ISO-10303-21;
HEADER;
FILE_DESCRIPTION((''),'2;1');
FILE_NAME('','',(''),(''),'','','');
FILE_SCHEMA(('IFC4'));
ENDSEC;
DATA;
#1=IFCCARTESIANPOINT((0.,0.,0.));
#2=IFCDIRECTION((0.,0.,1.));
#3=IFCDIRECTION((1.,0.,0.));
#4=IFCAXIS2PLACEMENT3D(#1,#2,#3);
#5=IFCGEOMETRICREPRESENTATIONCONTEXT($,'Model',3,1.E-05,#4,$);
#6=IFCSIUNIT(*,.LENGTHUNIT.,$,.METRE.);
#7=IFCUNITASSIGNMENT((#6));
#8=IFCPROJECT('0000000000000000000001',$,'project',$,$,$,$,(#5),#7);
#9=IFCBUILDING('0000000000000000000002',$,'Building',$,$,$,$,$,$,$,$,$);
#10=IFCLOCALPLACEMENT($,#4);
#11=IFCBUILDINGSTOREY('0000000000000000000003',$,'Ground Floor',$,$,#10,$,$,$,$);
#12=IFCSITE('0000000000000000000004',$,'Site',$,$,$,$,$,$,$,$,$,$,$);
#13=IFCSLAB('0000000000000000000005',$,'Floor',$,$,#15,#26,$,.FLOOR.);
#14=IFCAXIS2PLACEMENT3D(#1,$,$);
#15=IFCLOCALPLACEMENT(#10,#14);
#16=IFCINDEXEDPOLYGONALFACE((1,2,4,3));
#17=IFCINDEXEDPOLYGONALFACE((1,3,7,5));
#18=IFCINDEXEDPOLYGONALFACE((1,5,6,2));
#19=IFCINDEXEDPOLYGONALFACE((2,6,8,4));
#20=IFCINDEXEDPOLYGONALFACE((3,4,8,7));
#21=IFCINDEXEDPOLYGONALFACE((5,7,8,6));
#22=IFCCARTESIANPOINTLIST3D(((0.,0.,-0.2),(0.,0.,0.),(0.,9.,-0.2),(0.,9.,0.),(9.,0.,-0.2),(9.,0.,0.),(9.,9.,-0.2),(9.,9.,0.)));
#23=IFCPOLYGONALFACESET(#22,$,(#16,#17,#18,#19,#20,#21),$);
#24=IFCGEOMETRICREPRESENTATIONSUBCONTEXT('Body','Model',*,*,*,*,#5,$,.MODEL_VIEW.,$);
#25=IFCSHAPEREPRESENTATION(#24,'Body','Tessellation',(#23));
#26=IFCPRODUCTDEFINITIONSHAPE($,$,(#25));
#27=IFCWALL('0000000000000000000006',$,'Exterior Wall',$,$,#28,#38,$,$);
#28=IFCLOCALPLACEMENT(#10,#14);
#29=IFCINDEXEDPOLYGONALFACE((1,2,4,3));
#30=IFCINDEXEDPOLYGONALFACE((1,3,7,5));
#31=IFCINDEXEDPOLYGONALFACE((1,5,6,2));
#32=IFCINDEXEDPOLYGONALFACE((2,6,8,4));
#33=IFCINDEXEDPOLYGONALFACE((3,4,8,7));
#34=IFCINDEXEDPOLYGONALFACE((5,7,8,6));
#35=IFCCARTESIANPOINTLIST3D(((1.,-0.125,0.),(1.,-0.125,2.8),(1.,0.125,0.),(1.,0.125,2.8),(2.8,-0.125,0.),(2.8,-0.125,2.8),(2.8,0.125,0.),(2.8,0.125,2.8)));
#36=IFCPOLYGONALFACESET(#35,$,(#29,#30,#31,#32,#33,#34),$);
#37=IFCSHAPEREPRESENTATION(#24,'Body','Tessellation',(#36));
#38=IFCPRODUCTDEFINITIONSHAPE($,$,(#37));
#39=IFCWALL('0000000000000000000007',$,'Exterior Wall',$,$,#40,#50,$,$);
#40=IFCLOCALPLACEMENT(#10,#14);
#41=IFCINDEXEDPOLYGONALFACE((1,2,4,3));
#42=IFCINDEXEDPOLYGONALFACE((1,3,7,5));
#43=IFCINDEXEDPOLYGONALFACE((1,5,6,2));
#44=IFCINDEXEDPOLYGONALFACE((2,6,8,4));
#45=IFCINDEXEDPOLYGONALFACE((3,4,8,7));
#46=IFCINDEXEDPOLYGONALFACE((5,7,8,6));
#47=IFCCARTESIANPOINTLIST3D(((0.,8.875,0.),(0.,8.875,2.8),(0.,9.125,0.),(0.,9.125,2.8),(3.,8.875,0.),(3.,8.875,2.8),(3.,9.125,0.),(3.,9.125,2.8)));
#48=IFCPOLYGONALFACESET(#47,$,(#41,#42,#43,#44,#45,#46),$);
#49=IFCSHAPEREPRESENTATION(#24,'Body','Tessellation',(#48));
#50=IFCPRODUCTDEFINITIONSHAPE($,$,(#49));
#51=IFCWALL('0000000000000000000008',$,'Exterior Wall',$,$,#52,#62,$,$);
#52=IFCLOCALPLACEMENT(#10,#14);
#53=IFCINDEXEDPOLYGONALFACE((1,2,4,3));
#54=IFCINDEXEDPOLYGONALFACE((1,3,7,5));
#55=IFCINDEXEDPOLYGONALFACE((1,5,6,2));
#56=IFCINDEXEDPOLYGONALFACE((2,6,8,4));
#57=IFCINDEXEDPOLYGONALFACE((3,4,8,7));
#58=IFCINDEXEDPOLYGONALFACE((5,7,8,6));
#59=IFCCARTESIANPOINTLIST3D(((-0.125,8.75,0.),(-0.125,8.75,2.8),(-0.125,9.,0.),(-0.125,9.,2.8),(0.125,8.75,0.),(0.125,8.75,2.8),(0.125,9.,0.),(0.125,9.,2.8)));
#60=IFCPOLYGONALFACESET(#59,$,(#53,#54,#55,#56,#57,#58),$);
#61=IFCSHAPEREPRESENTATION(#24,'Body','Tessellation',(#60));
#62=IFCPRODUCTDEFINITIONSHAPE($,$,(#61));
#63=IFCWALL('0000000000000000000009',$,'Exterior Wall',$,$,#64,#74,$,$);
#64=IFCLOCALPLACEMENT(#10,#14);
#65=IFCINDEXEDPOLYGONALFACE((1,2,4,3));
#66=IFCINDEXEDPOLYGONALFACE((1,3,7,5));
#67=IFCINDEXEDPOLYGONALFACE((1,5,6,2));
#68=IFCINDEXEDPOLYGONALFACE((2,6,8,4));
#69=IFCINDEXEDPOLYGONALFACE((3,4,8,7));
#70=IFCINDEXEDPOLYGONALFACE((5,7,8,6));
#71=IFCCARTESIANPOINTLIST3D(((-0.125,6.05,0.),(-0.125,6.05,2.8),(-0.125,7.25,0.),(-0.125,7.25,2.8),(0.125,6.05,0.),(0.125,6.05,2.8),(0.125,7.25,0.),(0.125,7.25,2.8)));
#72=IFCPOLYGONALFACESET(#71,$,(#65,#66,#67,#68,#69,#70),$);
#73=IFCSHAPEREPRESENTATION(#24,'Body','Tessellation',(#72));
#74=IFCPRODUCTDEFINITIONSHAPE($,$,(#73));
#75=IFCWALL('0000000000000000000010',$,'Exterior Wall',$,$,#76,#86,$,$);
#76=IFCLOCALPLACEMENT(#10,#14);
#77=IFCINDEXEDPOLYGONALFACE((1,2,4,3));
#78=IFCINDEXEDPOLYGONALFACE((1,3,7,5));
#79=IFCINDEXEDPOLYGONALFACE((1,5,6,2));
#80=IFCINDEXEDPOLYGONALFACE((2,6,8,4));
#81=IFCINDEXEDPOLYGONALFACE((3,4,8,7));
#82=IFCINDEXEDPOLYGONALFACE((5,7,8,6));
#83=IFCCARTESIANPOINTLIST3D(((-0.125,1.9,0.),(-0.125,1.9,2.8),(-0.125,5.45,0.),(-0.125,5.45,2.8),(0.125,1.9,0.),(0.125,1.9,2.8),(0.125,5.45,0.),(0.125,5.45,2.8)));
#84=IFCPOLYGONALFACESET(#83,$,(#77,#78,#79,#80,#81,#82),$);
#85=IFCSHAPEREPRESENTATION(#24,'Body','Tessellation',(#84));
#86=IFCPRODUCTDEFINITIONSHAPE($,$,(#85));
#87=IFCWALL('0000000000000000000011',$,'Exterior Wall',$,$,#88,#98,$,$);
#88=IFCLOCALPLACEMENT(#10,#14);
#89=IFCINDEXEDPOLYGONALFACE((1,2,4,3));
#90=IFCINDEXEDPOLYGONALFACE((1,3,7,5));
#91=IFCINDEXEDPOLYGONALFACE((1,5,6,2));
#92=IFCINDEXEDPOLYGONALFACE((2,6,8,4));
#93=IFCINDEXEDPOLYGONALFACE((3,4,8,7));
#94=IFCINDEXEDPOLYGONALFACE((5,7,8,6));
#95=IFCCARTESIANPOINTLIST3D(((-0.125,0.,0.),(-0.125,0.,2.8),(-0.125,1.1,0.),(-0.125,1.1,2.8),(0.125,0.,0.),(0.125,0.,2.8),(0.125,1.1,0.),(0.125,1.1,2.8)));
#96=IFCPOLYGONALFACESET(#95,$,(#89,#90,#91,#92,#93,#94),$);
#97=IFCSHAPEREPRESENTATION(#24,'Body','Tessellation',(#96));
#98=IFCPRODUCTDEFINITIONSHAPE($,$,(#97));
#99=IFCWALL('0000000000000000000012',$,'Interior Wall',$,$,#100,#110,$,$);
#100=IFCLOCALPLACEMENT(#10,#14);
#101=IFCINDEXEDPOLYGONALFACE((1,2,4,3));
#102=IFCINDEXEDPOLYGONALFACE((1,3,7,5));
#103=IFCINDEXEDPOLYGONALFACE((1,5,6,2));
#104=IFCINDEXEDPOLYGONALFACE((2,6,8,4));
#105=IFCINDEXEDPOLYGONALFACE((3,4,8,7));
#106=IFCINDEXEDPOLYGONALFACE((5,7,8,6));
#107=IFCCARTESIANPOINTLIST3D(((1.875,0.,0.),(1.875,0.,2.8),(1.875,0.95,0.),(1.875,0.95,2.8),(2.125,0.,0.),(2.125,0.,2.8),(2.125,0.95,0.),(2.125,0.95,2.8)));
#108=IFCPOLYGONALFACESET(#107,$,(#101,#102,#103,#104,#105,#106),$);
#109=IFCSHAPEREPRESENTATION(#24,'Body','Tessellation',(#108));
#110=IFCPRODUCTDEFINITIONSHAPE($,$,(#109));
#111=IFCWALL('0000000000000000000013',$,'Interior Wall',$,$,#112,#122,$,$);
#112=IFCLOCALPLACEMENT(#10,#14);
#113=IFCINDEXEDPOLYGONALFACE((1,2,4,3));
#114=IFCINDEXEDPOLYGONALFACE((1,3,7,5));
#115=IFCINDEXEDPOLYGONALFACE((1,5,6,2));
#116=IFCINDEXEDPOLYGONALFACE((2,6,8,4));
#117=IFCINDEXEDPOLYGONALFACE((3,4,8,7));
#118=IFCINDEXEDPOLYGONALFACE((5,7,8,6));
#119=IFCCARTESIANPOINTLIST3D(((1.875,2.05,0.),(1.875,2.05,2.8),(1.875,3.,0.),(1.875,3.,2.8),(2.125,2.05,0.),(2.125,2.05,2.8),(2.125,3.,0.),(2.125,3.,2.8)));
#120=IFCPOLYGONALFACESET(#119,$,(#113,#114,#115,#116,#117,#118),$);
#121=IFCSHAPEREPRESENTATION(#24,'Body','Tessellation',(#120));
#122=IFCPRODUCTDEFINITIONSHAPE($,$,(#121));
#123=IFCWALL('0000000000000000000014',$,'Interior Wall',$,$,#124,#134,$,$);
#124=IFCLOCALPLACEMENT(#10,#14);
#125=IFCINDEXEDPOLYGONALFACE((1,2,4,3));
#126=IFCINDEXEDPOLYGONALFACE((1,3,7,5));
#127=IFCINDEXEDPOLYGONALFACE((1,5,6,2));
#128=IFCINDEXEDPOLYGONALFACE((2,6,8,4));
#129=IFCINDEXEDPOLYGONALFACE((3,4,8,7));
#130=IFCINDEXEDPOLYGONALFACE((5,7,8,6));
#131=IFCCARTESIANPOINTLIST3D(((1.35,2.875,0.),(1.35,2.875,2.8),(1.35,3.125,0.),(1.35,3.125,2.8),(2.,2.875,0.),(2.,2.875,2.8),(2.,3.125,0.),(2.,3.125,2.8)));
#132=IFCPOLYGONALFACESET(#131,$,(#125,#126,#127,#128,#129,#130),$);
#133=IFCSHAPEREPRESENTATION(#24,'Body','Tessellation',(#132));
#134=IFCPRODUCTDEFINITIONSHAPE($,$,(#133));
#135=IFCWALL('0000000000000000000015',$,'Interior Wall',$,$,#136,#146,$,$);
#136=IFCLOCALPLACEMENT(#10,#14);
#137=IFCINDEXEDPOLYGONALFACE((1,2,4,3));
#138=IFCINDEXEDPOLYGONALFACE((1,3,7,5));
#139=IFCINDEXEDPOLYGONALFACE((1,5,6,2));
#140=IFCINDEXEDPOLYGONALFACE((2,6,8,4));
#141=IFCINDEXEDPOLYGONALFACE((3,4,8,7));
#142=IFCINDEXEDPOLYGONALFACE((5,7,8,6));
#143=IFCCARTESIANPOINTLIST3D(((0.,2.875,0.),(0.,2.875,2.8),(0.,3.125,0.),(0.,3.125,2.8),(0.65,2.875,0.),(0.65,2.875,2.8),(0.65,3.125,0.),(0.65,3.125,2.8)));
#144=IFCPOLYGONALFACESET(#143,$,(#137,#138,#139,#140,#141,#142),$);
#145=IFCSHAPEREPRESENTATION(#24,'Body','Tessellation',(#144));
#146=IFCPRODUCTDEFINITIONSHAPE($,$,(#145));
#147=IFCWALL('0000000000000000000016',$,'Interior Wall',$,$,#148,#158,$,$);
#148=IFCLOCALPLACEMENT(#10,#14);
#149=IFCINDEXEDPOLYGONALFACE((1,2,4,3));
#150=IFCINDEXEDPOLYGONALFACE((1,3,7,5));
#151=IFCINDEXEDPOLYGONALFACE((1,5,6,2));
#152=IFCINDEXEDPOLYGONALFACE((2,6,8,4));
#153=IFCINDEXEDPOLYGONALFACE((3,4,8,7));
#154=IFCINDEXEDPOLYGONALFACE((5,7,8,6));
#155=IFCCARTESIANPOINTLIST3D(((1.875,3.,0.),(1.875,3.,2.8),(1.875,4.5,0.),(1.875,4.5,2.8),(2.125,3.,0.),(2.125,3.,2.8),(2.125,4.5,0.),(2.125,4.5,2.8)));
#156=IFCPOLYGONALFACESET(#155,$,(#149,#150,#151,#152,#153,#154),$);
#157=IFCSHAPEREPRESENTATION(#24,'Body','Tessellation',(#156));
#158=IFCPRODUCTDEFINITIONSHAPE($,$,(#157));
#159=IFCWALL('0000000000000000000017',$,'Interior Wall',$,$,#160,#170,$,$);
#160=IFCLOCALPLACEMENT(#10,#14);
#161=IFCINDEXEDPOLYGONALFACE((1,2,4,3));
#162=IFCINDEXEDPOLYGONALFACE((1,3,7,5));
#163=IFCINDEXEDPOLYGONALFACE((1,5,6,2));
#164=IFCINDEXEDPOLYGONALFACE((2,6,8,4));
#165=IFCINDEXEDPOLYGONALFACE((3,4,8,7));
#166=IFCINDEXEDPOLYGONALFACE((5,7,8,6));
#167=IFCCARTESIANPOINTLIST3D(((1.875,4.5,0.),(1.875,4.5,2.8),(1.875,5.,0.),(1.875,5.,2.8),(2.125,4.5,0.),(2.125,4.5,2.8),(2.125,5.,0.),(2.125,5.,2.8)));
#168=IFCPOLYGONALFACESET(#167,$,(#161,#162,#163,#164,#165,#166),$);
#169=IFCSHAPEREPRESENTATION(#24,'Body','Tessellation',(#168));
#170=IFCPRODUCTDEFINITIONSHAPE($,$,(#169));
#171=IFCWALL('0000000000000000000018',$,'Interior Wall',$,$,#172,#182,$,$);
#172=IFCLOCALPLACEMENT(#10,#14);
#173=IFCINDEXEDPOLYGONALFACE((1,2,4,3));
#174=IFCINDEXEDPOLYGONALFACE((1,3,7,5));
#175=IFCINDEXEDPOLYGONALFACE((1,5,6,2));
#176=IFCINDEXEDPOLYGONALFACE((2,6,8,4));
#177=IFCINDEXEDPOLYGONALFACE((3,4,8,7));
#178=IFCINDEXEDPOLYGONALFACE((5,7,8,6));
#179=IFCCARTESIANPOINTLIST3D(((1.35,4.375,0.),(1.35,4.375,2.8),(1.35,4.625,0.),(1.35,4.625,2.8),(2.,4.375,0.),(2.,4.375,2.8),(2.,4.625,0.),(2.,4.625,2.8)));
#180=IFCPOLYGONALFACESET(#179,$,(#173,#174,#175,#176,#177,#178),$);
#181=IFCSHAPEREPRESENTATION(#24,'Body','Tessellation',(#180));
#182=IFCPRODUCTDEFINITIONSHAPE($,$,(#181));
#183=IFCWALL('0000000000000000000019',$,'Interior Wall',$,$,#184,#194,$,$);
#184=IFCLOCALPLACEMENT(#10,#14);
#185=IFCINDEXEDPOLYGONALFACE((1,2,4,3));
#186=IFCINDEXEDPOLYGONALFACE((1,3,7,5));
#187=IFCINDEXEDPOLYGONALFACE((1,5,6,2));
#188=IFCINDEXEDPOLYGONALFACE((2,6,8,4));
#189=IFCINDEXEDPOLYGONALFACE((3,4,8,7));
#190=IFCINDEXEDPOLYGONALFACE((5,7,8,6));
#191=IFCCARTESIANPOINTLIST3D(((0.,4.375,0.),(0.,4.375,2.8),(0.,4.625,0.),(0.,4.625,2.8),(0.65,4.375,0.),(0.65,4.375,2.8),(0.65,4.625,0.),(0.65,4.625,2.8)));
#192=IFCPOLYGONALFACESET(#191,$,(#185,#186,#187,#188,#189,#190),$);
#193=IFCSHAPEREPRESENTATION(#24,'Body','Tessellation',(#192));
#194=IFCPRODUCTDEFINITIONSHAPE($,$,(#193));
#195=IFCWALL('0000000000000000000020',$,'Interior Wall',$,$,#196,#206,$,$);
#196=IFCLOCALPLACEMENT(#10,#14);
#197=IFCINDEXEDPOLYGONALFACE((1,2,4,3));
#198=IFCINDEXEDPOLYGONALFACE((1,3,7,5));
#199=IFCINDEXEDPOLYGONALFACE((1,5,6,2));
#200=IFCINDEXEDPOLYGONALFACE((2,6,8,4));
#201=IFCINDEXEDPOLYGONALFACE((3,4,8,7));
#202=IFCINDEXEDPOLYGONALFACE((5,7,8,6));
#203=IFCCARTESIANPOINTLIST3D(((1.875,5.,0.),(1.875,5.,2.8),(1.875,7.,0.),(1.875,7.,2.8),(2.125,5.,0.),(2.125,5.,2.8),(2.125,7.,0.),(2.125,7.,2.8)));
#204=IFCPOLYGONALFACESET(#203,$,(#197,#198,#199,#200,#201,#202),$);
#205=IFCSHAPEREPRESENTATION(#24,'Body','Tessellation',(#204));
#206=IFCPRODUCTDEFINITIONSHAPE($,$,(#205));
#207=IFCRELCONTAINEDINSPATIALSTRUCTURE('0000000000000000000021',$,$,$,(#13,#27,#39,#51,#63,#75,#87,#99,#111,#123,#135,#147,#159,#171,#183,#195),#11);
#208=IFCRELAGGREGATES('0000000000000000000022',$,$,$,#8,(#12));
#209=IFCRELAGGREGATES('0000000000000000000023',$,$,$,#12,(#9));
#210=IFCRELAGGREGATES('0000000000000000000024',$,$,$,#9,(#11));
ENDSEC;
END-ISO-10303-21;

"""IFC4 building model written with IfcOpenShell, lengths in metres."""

from ifc_helpers import new_model, si_unit, frame, origin_with_axes, place, context, subcontext, project, spatial, indexed_curve, outline, extrude, element, save


model = new_model("IFC4")

# Units and contexts
model_context = context("Model", 3, precision=1e-05, world=origin_with_axes())
body_context = subcontext(model_context, "Body", "Model", "MODEL_VIEW")
ifc_project = project(units=[si_unit("LENGTHUNIT", "METRE")], contexts=[model_context])

# Site, building, storey
site = spatial("IfcSite", under=ifc_project, Name="Site")
building = spatial("IfcBuilding", under=site, Name="Building")
storey_placement = place(None, origin_with_axes())
storey = spatial("IfcBuildingStorey", under=building, at=storey_placement, Name="Ground Floor")

# Slab
slab_placement = place(storey_placement, frame((0.0, 0.0, -0.2), z_axis=(0.0, 0.0, 1.0), x_axis=(1.0, 0.0, 0.0)))
element("IfcSlab", 1, at=slab_placement, inside=storey, Name="Floor", PredefinedType="FLOOR", context=body_context, shape_type="SweptSolid", body=[
    extrude(outline(indexed_curve([(0.0, 0.0), (9.0, 0.0), (9.0, 9.0), (0.0, 9.0)])), None, (0.0, 0.0, 1.0), 0.2),
])

# Walls
wall_1_placement = place(storey_placement, frame((1.0, 0.0, 0.0), z_axis=(0.0, 0.0, 1.0), x_axis=(1.0, 0.0, 0.0)))
element("IfcWall", 2, at=wall_1_placement, inside=storey, Name="Exterior Wall", context=body_context, shape_type="SweptSolid", body=[
    extrude(outline(indexed_curve([(0.0, 0.0), (0.0, 0.25), (1.8, 0.25), (1.8, 0.0), (0.0, 0.0)], self_intersect=False)), frame((0.0, -0.125, 0.0), z_axis=(0.0, 0.0, 1.0), x_axis=(1.0, 0.0, 0.0)), (0.0, 0.0, 1.0), 2.8),
])
wall_2_placement = place(storey_placement, frame((3.0, 9.0, 0.0), z_axis=(0.0, 0.0, 1.0), x_axis=(-1.0, 0.0, 0.0)))
element("IfcWall", 3, at=wall_2_placement, inside=storey, Name="Exterior Wall", context=body_context, shape_type="SweptSolid", body=[
    extrude(outline(indexed_curve([(0.0, 0.0), (0.0, 0.25), (3.0, 0.25), (3.0, 0.0), (0.0, 0.0)], self_intersect=False)), frame((0.0, -0.125, 0.0), z_axis=(0.0, 0.0, 1.0), x_axis=(1.0, 0.0, 0.0)), (0.0, 0.0, 1.0), 2.8),
])
wall_3_placement = place(storey_placement, frame((0.0, 9.0, 0.0), z_axis=(0.0, 0.0, 1.0), x_axis=(0.0, -1.0, 0.0)))
element("IfcWall", 4, at=wall_3_placement, inside=storey, Name="Exterior Wall", context=body_context, shape_type="SweptSolid", body=[
    extrude(outline(indexed_curve([(0.0, 0.0), (0.0, 0.25), (0.25, 0.25), (0.25, 0.0), (0.0, 0.0)], self_intersect=False)), frame((0.0, -0.125, 0.0), z_axis=(0.0, 0.0, 1.0), x_axis=(1.0, 0.0, 0.0)), (0.0, 0.0, 1.0), 2.8),
])
wall_4_placement = place(storey_placement, frame((0.0, 7.25, 0.0), z_axis=(0.0, 0.0, 1.0), x_axis=(0.0, -1.0, 0.0)))
element("IfcWall", 5, at=wall_4_placement, inside=storey, Name="Exterior Wall", context=body_context, shape_type="SweptSolid", body=[
    extrude(outline(indexed_curve([(0.0, 0.0), (0.0, 0.25), (1.2, 0.25), (1.2, 0.0), (0.0, 0.0)], self_intersect=False)), frame((0.0, -0.125, 0.0), z_axis=(0.0, 0.0, 1.0), x_axis=(1.0, 0.0, 0.0)), (0.0, 0.0, 1.0), 2.8),
])
wall_5_placement = place(storey_placement, frame((0.0, 5.45, 0.0), z_axis=(0.0, 0.0, 1.0), x_axis=(0.0, -1.0, 0.0)))
element("IfcWall", 6, at=wall_5_placement, inside=storey, Name="Exterior Wall", context=body_context, shape_type="SweptSolid", body=[
    extrude(outline(indexed_curve([(0.0, 0.0), (0.0, 0.25), (3.55, 0.25), (3.55, 0.0), (0.0, 0.0)], self_intersect=False)), frame((0.0, -0.125, 0.0), z_axis=(0.0, 0.0, 1.0), x_axis=(1.0, 0.0, 0.0)), (0.0, 0.0, 1.0), 2.8),
])
wall_6_placement = place(storey_placement, frame((0.0, 1.1, 0.0), z_axis=(0.0, 0.0, 1.0), x_axis=(0.0, -1.0, 0.0)))
element("IfcWall", 7, at=wall_6_placement, inside=storey, Name="Exterior Wall", context=body_context, shape_type="SweptSolid", body=[
    extrude(outline(indexed_curve([(0.0, 0.0), (0.0, 0.25), (1.1, 0.25), (1.1, 0.0), (0.0, 0.0)], self_intersect=False)), frame((0.0, -0.125, 0.0), z_axis=(0.0, 0.0, 1.0), x_axis=(1.0, 0.0, 0.0)), (0.0, 0.0, 1.0), 2.8),
])
wall_7_placement = place(storey_placement, frame((2.0, 0.0, 0.0), z_axis=(0.0, 0.0, 1.0), x_axis=(0.0, 1.0, 0.0)))
element("IfcWall", 8, at=wall_7_placement, inside=storey, Name="Interior Wall", context=body_context, shape_type="SweptSolid", body=[
    extrude(outline(indexed_curve([(0.0, 0.0), (0.0, 0.25), (0.95, 0.25), (0.95, 0.0), (0.0, 0.0)], self_intersect=False)), frame((0.0, -0.125, 0.0), z_axis=(0.0, 0.0, 1.0), x_axis=(1.0, 0.0, 0.0)), (0.0, 0.0, 1.0), 2.8),
])
wall_8_placement = place(storey_placement, frame((2.0, 2.05, 0.0), z_axis=(0.0, 0.0, 1.0), x_axis=(0.0, 1.0, 0.0)))
element("IfcWall", 9, at=wall_8_placement, inside=storey, Name="Interior Wall", context=body_context, shape_type="SweptSolid", body=[
    extrude(outline(indexed_curve([(0.0, 0.0), (0.0, 0.25), (0.95, 0.25), (0.95, 0.0), (0.0, 0.0)], self_intersect=False)), frame((0.0, -0.125, 0.0), z_axis=(0.0, 0.0, 1.0), x_axis=(1.0, 0.0, 0.0)), (0.0, 0.0, 1.0), 2.8),
])
for number, where, z_axis, x_axis, name in (
    (10, (2.0, 3.0, 0.0), (0.0, 0.0, 1.0), (-1.0, 0.0, 0.0), "Interior Wall"),
    (11, (0.65, 3.0, 0.0), (0.0, 0.0, 1.0), (-1.0, 0.0, 0.0), "Interior Wall"),
):
    element("IfcWall", number, at=place(storey_placement, frame(where, z_axis=z_axis, x_axis=x_axis)), inside=storey, Name=name, context=body_context, shape_type="SweptSolid", body=[
        extrude(outline(indexed_curve([(0.0, 0.0), (0.0, 0.25), (0.65, 0.25), (0.65, 0.0), (0.0, 0.0)], self_intersect=False)), frame((0.0, -0.125, 0.0), z_axis=(0.0, 0.0, 1.0), x_axis=(1.0, 0.0, 0.0)), (0.0, 0.0, 1.0), 2.8),
    ])
wall_9_placement = place(storey_placement, frame((2.0, 4.5, 0.0), z_axis=(0.0, 0.0, 1.0), x_axis=(0.0, -1.0, 0.0)))
element("IfcWall", 12, at=wall_9_placement, inside=storey, Name="Interior Wall", context=body_context, shape_type="SweptSolid", body=[
    extrude(outline(indexed_curve([(0.0, 0.0), (0.0, 0.25), (1.5, 0.25), (1.5, 0.0), (0.0, 0.0)], self_intersect=False)), frame((0.0, -0.125, 0.0), z_axis=(0.0, 0.0, 1.0), x_axis=(1.0, 0.0, 0.0)), (0.0, 0.0, 1.0), 2.8),
])
wall_10_placement = place(storey_placement, frame((2.0, 5.0, 0.0), z_axis=(0.0, 0.0, 1.0), x_axis=(0.0, -1.0, 0.0)))
element("IfcWall", 13, at=wall_10_placement, inside=storey, Name="Interior Wall", context=body_context, shape_type="SweptSolid", body=[
    extrude(outline(indexed_curve([(0.0, 0.0), (0.0, 0.25), (0.5, 0.25), (0.5, 0.0), (0.0, 0.0)], self_intersect=False)), frame((0.0, -0.125, 0.0), z_axis=(0.0, 0.0, 1.0), x_axis=(1.0, 0.0, 0.0)), (0.0, 0.0, 1.0), 2.8),
])
for number, where, z_axis, x_axis, name in (
    (14, (2.0, 4.5, 0.0), (0.0, 0.0, 1.0), (-1.0, 0.0, 0.0), "Interior Wall"),
    (15, (0.65, 4.5, 0.0), (0.0, 0.0, 1.0), (-1.0, 0.0, 0.0), "Interior Wall"),
):
    element("IfcWall", number, at=place(storey_placement, frame(where, z_axis=z_axis, x_axis=x_axis)), inside=storey, Name=name, context=body_context, shape_type="SweptSolid", body=[
        extrude(outline(indexed_curve([(0.0, 0.0), (0.0, 0.25), (0.65, 0.25), (0.65, 0.0), (0.0, 0.0)], self_intersect=False)), frame((0.0, -0.125, 0.0), z_axis=(0.0, 0.0, 1.0), x_axis=(1.0, 0.0, 0.0)), (0.0, 0.0, 1.0), 2.8),
    ])
wall_11_placement = place(storey_placement, frame((2.0, 5.0, 0.0), z_axis=(0.0, 0.0, 1.0), x_axis=(0.0, 1.0, 0.0)))
element("IfcWall", 16, at=wall_11_placement, inside=storey, Name="Interior Wall", context=body_context, shape_type="SweptSolid", body=[
    extrude(outline(indexed_curve([(0.0, 0.0), (0.0, 0.25), (2.0, 0.25), (2.0, 0.0), (0.0, 0.0)], self_intersect=False)), frame((0.0, -0.125, 0.0), z_axis=(0.0, 0.0, 1.0), x_axis=(1.0, 0.0, 0.0)), (0.0, 0.0, 1.0), 2.8),
])

save(model, "model.ifc")
